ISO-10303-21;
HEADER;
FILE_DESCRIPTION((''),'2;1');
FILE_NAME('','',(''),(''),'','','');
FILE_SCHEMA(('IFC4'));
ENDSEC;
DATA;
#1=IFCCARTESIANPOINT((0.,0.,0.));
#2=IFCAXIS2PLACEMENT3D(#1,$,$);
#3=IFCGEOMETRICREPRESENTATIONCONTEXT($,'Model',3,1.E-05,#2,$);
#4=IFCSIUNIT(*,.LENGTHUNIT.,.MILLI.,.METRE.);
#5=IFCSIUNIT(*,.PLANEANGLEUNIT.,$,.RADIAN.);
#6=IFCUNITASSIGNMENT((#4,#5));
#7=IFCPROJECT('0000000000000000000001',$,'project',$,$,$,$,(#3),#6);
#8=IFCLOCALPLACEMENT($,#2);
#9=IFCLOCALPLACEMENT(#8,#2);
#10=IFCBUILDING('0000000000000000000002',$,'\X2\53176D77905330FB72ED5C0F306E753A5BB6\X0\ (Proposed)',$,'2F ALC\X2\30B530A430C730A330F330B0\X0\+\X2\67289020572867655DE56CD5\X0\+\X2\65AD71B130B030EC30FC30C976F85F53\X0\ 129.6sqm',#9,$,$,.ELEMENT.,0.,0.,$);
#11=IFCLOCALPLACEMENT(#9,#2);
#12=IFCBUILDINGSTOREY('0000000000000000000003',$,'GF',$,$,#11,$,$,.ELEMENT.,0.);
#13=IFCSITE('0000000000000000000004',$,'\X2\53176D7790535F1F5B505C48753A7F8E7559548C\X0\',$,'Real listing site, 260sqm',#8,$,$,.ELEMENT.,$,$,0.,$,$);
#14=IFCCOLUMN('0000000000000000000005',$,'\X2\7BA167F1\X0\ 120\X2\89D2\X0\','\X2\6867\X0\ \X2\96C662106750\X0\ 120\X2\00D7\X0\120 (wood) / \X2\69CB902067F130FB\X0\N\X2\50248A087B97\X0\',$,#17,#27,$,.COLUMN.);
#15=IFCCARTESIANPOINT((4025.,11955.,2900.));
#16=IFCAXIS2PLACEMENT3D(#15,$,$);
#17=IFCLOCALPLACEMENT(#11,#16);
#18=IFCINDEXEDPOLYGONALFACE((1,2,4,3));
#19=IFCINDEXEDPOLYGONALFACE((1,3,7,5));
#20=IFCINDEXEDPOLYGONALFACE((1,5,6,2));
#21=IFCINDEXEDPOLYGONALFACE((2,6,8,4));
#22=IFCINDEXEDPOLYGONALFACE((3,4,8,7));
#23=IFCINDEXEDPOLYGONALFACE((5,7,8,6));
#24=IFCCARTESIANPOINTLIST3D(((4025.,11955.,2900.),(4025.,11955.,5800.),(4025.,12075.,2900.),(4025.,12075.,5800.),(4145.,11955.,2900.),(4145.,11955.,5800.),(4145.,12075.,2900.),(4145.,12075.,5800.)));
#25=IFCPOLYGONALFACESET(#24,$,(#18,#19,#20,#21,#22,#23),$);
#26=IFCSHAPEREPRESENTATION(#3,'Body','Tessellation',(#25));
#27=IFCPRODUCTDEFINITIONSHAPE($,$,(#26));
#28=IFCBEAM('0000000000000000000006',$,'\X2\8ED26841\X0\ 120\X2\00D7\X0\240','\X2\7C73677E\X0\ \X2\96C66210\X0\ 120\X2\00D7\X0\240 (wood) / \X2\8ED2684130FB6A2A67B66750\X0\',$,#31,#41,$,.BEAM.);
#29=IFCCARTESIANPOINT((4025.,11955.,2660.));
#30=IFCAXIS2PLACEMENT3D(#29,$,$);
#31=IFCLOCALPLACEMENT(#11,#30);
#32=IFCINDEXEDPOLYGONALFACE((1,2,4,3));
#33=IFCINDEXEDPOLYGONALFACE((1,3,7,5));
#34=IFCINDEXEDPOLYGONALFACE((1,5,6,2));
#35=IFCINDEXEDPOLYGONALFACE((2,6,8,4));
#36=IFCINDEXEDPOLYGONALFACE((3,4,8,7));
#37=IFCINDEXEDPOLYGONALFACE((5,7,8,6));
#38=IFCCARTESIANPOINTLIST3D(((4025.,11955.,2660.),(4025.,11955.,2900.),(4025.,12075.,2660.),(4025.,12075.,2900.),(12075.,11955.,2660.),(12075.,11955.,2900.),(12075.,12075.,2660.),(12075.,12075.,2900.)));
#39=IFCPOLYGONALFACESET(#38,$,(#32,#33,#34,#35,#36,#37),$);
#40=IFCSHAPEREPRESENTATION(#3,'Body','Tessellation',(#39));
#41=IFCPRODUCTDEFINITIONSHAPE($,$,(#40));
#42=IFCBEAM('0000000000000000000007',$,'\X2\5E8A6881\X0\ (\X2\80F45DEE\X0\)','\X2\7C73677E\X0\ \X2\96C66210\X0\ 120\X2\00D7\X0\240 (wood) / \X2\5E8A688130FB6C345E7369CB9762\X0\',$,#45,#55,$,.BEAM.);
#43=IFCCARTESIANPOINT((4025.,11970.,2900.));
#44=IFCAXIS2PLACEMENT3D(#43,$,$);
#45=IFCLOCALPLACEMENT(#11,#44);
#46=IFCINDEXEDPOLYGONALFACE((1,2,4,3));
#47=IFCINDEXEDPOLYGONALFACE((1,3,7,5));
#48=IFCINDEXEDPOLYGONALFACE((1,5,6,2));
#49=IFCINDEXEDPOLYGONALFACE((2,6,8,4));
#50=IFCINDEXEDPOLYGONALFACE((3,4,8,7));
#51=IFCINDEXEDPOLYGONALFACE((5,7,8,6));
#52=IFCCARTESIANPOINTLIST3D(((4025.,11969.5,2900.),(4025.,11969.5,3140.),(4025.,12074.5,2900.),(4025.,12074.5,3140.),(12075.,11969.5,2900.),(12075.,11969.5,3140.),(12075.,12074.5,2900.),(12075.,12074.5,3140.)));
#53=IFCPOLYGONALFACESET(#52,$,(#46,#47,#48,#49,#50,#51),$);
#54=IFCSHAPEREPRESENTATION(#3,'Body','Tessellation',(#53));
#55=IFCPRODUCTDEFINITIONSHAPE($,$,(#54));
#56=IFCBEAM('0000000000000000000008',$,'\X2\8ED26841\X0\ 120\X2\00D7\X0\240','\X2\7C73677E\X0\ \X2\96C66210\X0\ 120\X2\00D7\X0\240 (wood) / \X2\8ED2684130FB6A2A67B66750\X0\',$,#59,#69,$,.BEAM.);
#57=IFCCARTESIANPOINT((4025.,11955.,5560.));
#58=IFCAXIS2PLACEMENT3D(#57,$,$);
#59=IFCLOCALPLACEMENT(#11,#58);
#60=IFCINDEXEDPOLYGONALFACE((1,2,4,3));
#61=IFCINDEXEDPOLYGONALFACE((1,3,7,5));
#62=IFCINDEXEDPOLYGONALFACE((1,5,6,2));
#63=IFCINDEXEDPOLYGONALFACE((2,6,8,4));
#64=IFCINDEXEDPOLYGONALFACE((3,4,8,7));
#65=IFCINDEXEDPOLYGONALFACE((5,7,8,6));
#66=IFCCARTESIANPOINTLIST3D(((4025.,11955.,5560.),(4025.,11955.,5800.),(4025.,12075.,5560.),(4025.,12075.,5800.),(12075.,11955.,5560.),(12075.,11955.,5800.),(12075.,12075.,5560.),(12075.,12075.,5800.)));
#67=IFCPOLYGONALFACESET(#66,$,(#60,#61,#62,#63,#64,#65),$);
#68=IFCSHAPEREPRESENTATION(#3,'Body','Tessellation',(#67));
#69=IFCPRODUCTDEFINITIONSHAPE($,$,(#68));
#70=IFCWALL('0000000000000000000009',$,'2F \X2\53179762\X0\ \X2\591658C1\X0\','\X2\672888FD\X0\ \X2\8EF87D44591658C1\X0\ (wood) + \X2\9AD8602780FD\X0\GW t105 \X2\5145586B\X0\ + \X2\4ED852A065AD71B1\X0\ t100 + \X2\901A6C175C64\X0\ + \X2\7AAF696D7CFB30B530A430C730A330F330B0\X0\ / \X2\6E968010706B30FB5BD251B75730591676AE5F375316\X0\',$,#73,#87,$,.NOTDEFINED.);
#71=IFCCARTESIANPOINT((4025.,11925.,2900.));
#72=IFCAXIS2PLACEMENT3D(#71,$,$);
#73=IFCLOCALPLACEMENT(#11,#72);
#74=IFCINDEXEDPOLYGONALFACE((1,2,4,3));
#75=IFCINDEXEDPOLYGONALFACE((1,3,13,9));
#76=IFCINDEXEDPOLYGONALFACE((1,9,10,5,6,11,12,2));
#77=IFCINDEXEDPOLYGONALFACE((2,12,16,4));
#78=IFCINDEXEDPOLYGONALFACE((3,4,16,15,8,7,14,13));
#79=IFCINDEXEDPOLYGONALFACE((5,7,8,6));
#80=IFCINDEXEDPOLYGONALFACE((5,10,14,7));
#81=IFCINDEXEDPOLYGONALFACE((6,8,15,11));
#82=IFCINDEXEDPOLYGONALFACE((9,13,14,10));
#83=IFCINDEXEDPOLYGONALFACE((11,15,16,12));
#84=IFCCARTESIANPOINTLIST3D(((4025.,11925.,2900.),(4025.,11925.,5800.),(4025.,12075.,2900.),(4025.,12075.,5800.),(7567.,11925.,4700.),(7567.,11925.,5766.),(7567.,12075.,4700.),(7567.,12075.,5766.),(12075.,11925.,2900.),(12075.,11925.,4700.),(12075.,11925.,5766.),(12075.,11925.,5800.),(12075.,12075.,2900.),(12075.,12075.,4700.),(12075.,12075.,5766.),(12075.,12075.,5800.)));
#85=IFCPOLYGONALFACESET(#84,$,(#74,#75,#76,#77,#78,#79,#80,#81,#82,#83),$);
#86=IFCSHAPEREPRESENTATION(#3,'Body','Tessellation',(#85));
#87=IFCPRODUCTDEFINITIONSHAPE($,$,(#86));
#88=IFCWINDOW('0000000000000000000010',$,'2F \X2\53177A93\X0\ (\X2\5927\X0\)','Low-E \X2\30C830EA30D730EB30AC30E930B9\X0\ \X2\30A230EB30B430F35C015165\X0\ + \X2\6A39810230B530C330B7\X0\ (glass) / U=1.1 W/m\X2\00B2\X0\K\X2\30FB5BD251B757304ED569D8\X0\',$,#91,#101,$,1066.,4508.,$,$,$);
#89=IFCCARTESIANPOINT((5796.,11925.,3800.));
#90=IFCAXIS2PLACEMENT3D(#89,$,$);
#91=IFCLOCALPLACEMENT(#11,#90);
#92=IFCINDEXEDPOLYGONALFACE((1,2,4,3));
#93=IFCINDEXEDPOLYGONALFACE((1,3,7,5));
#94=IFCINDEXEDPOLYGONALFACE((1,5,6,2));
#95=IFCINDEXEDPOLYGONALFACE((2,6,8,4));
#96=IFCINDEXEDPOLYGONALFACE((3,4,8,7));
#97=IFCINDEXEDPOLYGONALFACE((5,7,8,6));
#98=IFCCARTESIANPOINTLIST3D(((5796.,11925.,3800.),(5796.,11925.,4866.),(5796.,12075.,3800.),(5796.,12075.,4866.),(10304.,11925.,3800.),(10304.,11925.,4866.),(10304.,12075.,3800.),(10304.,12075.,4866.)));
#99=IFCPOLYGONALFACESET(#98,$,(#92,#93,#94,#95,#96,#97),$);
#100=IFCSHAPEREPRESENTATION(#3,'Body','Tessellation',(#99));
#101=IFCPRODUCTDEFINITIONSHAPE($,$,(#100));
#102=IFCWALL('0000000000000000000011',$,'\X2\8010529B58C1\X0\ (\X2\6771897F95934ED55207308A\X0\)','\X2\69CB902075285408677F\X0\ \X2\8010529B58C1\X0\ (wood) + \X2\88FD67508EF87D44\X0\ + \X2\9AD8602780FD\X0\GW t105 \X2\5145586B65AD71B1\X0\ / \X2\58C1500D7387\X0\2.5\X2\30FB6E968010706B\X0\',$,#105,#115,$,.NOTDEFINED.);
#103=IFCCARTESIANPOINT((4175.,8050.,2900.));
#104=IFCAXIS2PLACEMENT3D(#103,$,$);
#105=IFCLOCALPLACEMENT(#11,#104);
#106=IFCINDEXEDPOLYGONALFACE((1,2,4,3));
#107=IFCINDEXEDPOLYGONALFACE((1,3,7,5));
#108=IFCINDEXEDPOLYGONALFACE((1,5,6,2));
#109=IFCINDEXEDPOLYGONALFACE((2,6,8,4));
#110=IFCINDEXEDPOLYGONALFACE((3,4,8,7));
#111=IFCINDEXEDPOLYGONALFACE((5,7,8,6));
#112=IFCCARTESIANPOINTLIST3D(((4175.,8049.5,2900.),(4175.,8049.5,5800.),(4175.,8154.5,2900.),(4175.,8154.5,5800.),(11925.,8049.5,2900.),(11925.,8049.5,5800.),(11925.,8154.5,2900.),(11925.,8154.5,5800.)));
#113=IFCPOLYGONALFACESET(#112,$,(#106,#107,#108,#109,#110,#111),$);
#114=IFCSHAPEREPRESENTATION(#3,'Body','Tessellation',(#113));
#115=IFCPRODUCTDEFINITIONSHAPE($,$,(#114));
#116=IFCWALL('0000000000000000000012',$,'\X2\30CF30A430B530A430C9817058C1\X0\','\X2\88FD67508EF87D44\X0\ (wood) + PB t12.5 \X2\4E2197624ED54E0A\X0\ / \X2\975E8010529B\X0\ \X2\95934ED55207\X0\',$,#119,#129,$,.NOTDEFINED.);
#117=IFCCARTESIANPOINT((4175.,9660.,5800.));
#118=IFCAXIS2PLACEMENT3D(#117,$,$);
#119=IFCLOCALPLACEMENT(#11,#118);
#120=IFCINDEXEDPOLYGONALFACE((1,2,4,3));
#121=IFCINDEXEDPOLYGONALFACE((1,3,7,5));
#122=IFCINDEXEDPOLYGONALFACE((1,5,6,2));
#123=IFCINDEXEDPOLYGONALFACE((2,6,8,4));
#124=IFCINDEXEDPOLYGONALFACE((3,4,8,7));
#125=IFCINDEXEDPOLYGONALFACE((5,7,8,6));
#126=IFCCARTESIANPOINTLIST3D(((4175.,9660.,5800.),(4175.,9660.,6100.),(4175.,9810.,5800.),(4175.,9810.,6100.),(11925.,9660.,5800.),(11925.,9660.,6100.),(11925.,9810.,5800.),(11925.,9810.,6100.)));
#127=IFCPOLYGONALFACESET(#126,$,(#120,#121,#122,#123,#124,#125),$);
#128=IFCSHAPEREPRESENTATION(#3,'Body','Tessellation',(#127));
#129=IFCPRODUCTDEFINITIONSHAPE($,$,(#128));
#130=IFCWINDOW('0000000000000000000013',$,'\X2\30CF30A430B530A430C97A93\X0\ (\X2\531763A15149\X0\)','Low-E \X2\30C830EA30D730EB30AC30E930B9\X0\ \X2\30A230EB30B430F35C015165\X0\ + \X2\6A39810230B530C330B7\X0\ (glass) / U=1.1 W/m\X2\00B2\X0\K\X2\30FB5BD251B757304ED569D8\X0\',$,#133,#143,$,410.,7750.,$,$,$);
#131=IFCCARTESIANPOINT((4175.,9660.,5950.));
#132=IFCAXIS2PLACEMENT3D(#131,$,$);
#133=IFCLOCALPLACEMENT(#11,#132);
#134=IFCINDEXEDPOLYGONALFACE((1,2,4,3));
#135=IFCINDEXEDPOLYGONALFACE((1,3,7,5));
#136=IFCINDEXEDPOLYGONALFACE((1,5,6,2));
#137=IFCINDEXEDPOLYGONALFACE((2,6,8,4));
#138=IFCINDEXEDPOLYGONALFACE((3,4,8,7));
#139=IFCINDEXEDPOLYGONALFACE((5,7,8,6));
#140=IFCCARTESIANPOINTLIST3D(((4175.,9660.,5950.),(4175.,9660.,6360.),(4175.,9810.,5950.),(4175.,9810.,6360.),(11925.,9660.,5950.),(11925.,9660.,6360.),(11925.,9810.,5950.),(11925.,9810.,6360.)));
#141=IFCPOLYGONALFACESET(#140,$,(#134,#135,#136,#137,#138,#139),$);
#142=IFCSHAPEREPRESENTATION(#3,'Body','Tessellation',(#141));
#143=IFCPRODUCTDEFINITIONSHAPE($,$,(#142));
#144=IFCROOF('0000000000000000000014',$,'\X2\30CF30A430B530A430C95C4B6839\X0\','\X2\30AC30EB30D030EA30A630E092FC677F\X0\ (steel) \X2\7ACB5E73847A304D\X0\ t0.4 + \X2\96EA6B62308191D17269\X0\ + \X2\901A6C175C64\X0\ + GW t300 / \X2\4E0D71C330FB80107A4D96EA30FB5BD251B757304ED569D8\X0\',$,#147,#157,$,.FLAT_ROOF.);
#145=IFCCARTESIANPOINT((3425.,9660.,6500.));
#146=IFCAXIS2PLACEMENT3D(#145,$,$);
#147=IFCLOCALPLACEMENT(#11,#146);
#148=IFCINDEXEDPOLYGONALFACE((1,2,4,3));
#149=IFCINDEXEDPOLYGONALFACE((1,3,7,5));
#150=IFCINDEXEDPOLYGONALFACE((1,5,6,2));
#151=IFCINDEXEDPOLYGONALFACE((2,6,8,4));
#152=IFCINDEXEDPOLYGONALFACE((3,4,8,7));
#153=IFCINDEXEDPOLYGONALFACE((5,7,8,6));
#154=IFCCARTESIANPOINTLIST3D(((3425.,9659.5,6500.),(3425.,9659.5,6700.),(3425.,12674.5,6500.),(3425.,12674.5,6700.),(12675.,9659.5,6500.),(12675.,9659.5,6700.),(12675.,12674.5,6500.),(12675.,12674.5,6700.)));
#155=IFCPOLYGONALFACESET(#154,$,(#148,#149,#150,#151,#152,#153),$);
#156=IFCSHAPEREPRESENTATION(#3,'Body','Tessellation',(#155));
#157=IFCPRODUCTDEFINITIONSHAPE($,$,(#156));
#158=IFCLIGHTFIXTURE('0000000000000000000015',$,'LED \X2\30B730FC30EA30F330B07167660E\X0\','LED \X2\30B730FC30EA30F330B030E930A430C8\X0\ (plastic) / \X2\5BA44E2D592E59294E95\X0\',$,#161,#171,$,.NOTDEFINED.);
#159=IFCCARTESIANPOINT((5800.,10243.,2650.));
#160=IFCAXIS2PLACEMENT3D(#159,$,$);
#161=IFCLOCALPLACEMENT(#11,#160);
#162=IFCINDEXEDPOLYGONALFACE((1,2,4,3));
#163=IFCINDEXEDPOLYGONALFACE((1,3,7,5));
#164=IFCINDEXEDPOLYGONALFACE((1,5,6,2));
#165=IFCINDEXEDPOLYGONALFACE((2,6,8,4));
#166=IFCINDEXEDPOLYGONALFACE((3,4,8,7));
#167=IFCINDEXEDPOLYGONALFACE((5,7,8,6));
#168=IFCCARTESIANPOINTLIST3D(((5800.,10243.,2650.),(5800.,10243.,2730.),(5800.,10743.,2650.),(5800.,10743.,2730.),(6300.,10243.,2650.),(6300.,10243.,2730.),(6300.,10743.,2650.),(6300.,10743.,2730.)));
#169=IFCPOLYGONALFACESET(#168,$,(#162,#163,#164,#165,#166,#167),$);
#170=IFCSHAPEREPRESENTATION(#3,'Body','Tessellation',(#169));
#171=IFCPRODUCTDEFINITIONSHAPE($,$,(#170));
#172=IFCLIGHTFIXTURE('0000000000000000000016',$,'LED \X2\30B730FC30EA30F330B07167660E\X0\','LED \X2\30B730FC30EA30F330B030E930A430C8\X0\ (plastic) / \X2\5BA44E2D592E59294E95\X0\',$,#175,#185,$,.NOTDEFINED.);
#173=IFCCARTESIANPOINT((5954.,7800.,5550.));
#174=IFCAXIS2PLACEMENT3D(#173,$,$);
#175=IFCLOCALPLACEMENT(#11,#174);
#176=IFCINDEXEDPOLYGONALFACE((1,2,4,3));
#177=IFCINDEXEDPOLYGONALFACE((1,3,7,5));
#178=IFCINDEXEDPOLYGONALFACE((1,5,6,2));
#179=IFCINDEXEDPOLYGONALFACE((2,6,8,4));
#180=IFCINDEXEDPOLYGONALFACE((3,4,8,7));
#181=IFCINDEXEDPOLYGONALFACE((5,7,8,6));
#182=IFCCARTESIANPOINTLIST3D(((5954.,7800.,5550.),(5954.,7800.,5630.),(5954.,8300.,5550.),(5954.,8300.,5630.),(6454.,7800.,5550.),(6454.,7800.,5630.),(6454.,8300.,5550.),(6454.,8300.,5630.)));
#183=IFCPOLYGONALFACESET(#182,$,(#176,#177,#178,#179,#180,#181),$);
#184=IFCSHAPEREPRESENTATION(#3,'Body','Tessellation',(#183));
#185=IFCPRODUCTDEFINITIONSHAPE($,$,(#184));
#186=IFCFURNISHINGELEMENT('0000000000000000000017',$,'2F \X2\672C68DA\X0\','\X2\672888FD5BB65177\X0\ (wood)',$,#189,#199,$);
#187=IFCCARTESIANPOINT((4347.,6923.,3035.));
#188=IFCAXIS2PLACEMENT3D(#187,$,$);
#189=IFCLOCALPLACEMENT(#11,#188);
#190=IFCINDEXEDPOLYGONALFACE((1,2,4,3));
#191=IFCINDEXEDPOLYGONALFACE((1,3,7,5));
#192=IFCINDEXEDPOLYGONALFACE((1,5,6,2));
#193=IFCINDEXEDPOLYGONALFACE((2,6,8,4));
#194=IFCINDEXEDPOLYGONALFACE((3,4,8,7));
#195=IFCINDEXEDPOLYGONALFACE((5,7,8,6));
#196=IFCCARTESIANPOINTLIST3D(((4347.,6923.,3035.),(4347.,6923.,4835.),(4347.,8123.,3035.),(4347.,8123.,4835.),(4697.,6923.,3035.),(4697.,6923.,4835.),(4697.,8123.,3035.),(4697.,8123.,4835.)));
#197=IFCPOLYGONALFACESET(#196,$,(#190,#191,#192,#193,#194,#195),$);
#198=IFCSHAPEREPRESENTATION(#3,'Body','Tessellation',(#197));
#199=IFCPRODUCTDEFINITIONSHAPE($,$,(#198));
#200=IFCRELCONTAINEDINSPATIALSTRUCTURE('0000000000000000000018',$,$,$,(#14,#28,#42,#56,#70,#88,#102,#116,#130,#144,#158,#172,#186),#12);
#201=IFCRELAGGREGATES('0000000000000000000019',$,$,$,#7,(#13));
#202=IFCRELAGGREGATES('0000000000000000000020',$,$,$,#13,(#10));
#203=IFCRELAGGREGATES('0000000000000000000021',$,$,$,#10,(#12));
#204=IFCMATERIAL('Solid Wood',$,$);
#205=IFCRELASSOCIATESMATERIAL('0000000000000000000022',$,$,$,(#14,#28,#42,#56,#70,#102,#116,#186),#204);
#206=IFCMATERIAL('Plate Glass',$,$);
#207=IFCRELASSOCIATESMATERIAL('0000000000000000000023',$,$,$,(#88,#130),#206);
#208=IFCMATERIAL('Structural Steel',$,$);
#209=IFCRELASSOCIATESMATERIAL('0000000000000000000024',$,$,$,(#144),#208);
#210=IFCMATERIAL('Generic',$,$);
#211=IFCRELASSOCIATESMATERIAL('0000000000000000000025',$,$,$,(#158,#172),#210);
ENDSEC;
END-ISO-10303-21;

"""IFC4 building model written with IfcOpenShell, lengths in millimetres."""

from ifc_helpers import new_model, si_unit, frame, frame_2d, origin, place, context, project, spatial, rectangle, extrude, material, element, fill, save


model = new_model("IFC4")

# Units and contexts
model_context = context("Model", 3, precision=1e-05, world=origin())
ifc_project = project(units=[si_unit("LENGTHUNIT", "METRE", prefix="MILLI"), si_unit("PLANEANGLEUNIT", "RADIAN")], contexts=[model_context])

# Site, building, storey
site_placement = place(None, origin())
site = spatial("IfcSite", under=ifc_project, at=site_placement, Name="北海道弟子屈町美留和", ObjectType="Real listing site, 260sqm", CompositionType="ELEMENT", RefElevation=0.0)
building_placement = place(site_placement, origin())
building = spatial("IfcBuilding", under=site, at=building_placement, Name="北海道・狭小の町家 (Proposed)", ObjectType="2F ALCサイディング+木造在来工法+断熱グレード相当 129.6sqm", CompositionType="ELEMENT", ElevationOfRefHeight=0.0, ElevationOfTerrain=0.0)
storey_placement = place(building_placement, origin())
storey = spatial("IfcBuildingStorey", under=building, at=storey_placement, Name="GF", CompositionType="ELEMENT", Elevation=0.0)

# Column
ifc_material_1 = material(Name="Solid Wood")
column_1_placement = place(storey_placement, frame((4025.0, 11955.0, 2900.0)))
element("IfcColumn", 1, at=column_1_placement, inside=storey, material=ifc_material_1, Name="管柱 120角", Description="桧 集成材 120×120 (wood) / 構造柱・N値計算", PredefinedType="COLUMN", context=model_context, shape_type="SweptSolid", body=[
    extrude(rectangle(XDim=120.0, YDim=120.0, at=frame_2d((60.0, 60.0))), frame((4025.0, 11955.0, 2900.0)), (0.0, 0.0, 1.0), 2900.0),
])

# Beams
beam_1_placement = place(storey_placement, frame((4025.0, 11955.0, 2660.0)))
element("IfcBeam", 2, at=beam_1_placement, inside=storey, material=ifc_material_1, Name="軒桁 120×240", Description="米松 集成 120×240 (wood) / 軒桁・横架材", PredefinedType="BEAM", context=model_context, shape_type="SweptSolid", body=[
    extrude(rectangle(XDim=8050.0, YDim=120.0, at=frame_2d((4025.0, 60.0))), frame((4025.0, 11955.0, 2660.0)), (0.0, 0.0, 1.0), 240.0),
])
beam_2_placement = place(storey_placement, frame((4025.0, 11970.0, 2900.0)))
element("IfcBeam", 3, at=beam_2_placement, inside=storey, material=ifc_material_1, Name="床梁 (胴差)", Description="米松 集成 120×240 (wood) / 床梁・水平構面", PredefinedType="BEAM", context=model_context, shape_type="SweptSolid", body=[
    extrude(rectangle(XDim=8050.0, YDim=105.0, at=frame_2d((4025.0, 52.0))), frame((4025.0, 11970.0, 2900.0)), (0.0, 0.0, 1.0), 240.0),
])
beam_3_placement = place(storey_placement, frame((4025.0, 11955.0, 5560.0)))
element("IfcBeam", 4, at=beam_3_placement, inside=storey, material=ifc_material_1, Name="軒桁 120×240", Description="米松 集成 120×240 (wood) / 軒桁・横架材", PredefinedType="BEAM", context=model_context, shape_type="SweptSolid", body=[
    extrude(rectangle(XDim=8050.0, YDim=120.0, at=frame_2d((4025.0, 60.0))), frame((4025.0, 11955.0, 5560.0)), (0.0, 0.0, 1.0), 240.0),
])

# Wall, opening, window
wall_1_placement = place(storey_placement, frame((4025.0, 11925.0, 2900.0)))
wall_1 = element("IfcWall", 5, at=wall_1_placement, inside=storey, material=ifc_material_1, Name="2F 北面 外壁", Description="木製 軸組外壁 (wood) + 高性能GW t105 充填 + 付加断熱 t100 + 通気層 + 窯業系サイディング / 準耐火・寒冷地外皮強化", PredefinedType="NOTDEFINED", context=model_context, shape_type="SweptSolid", body=[
    extrude(rectangle(XDim=8050.0, YDim=150.0, at=frame_2d((4025.0, 75.0))), frame((4025.0, 11925.0, 2900.0)), (0.0, 0.0, 1.0), 2900.0),
])
opening_1_placement = place(storey_placement, frame((5796.0, 11925.0, 3800.0)))
opening_1 = element("IfcOpeningElement", 6, at=opening_1_placement, cuts=wall_1, PredefinedType="NOTDEFINED", context=model_context, shape_type="SweptSolid", body=[
    extrude(rectangle(XDim=4508.0, YDim=150.0, at=frame_2d((2254.0, 75.0))), frame((5796.0, 11925.0, 3800.0)), (0.0, 0.0, 1.0), 1066.0),
])
ifc_material_2 = material(Name="Plate Glass")
window_1_placement = place(storey_placement, frame((5796.0, 11925.0, 3800.0)))
window_1 = element("IfcWindow", 7, at=window_1_placement, inside=storey, material=ifc_material_2, Name="2F 北窓 (大)", Description="Low-E トリプルガラス アルゴン封入 + 樹脂サッシ (glass) / U=1.1 W/m²K・寒冷地仕様", OverallHeight=1066.0, OverallWidth=4508.0, context=model_context, shape_type="SweptSolid", body=[
    extrude(rectangle(XDim=4508.0, YDim=150.0, at=frame_2d((2254.0, 75.0))), frame((5796.0, 11925.0, 3800.0)), (0.0, 0.0, 1.0), 1066.0),
])
fill(opening_1, window_1)

# Wall
wall_2_placement = place(storey_placement, frame((4175.0, 8050.0, 2900.0)))
element("IfcWall", 8, at=wall_2_placement, inside=storey, material=ifc_material_1, Name="耐力壁 (東西間仕切り)", Description="構造用合板 耐力壁 (wood) + 製材軸組 + 高性能GW t105 充填断熱 / 壁倍率2.5・準耐火", PredefinedType="NOTDEFINED", context=model_context, shape_type="SweptSolid", body=[
    extrude(rectangle(XDim=7750.0, YDim=105.0, at=frame_2d((3875.0, 52.0))), frame((4175.0, 8050.0, 2900.0)), (0.0, 0.0, 1.0), 2900.0),
])

# Wall, opening, window
wall_3_placement = place(storey_placement, frame((4175.0, 9660.0, 5800.0)))
wall_3 = element("IfcWall", 9, at=wall_3_placement, inside=storey, material=ifc_material_1, Name="ハイサイド腰壁", Description="製材軸組 (wood) + PB t12.5 両面仕上 / 非耐力 間仕切", PredefinedType="NOTDEFINED", context=model_context, shape_type="SweptSolid", body=[
    extrude(rectangle(XDim=7750.0, YDim=150.0, at=frame_2d((3875.0, 75.0))), frame((4175.0, 9660.0, 5800.0)), (0.0, 0.0, 1.0), 700.0),
])
opening_2_placement = place(storey_placement, frame((4175.0, 9660.0, 5950.0)))
opening_2 = element("IfcOpeningElement", 10, at=opening_2_placement, cuts=wall_3, PredefinedType="NOTDEFINED", context=model_context, shape_type="SweptSolid", body=[
    extrude(rectangle(XDim=7750.0, YDim=150.0, at=frame_2d((3875.0, 75.0))), frame((4175.0, 9660.0, 5950.0)), (0.0, 0.0, 1.0), 410.0),
])
window_2_placement = place(storey_placement, frame((4175.0, 9660.0, 5950.0)))
window_2 = element("IfcWindow", 11, at=window_2_placement, inside=storey, material=ifc_material_2, Name="ハイサイド窓 (北採光)", Description="Low-E トリプルガラス アルゴン封入 + 樹脂サッシ (glass) / U=1.1 W/m²K・寒冷地仕様", OverallHeight=410.0, OverallWidth=7750.0, context=model_context, shape_type="SweptSolid", body=[
    extrude(rectangle(XDim=7750.0, YDim=150.0, at=frame_2d((3875.0, 75.0))), frame((4175.0, 9660.0, 5950.0)), (0.0, 0.0, 1.0), 410.0),
])
fill(opening_2, window_2)

# Roof
ifc_material_3 = material(Name="Structural Steel")
roof_placement = place(storey_placement, frame((3425.0, 9660.0, 6500.0)))
element("IfcRoof", 12, at=roof_placement, inside=storey, material=ifc_material_3, Name="ハイサイド屋根", Description="ガルバリウム鋼板 (steel) 立平葺き t0.4 + 雪止め金物 + 通気層 + GW t300 / 不燃・耐積雪・寒冷地仕様", PredefinedType="FLAT_ROOF", context=model_context, shape_type="SweptSolid", body=[
    extrude(rectangle(XDim=9250.0, YDim=3015.0, at=frame_2d((4625.0, 1507.0))), frame((3425.0, 9660.0, 6500.0)), (0.0, 0.0, 1.0), 200.0),
])

# Light fixtures
ifc_material_4 = material(Name="Generic")
light_fixture_1_placement = place(storey_placement, frame((5800.0, 10243.0, 2650.0)))
element("IfcLightFixture", 13, at=light_fixture_1_placement, inside=storey, material=ifc_material_4, Name="LED シーリング照明", Description="LED シーリングライト (plastic) / 室中央天井", PredefinedType="NOTDEFINED", context=model_context, shape_type="SweptSolid", body=[
    extrude(rectangle(XDim=500.0, YDim=500.0, at=frame_2d((250.0, 250.0))), frame((5800.0, 10243.0, 2650.0)), (0.0, 0.0, 1.0), 80.0),
])
light_fixture_2_placement = place(storey_placement, frame((5954.0, 7800.0, 5550.0)))
element("IfcLightFixture", 14, at=light_fixture_2_placement, inside=storey, material=ifc_material_4, Name="LED シーリング照明", Description="LED シーリングライト (plastic) / 室中央天井", PredefinedType="NOTDEFINED", context=model_context, shape_type="SweptSolid", body=[
    extrude(rectangle(XDim=500.0, YDim=500.0, at=frame_2d((250.0, 250.0))), frame((5954.0, 7800.0, 5550.0)), (0.0, 0.0, 1.0), 80.0),
])

# Furnishing element
furnishing_placement = place(storey_placement, frame((4347.0, 6923.0, 3035.0)))
element("IfcFurnishingElement", 15, at=furnishing_placement, inside=storey, material=ifc_material_1, Name="2F 本棚", Description="木製家具 (wood)", context=model_context, shape_type="SweptSolid", body=[
    extrude(rectangle(XDim=350.0, YDim=1200.0, at=frame_2d((175.0, 600.0))), frame((4347.0, 6923.0, 3035.0)), (0.0, 0.0, 1.0), 1800.0),
])

save(model, "model.ifc")
